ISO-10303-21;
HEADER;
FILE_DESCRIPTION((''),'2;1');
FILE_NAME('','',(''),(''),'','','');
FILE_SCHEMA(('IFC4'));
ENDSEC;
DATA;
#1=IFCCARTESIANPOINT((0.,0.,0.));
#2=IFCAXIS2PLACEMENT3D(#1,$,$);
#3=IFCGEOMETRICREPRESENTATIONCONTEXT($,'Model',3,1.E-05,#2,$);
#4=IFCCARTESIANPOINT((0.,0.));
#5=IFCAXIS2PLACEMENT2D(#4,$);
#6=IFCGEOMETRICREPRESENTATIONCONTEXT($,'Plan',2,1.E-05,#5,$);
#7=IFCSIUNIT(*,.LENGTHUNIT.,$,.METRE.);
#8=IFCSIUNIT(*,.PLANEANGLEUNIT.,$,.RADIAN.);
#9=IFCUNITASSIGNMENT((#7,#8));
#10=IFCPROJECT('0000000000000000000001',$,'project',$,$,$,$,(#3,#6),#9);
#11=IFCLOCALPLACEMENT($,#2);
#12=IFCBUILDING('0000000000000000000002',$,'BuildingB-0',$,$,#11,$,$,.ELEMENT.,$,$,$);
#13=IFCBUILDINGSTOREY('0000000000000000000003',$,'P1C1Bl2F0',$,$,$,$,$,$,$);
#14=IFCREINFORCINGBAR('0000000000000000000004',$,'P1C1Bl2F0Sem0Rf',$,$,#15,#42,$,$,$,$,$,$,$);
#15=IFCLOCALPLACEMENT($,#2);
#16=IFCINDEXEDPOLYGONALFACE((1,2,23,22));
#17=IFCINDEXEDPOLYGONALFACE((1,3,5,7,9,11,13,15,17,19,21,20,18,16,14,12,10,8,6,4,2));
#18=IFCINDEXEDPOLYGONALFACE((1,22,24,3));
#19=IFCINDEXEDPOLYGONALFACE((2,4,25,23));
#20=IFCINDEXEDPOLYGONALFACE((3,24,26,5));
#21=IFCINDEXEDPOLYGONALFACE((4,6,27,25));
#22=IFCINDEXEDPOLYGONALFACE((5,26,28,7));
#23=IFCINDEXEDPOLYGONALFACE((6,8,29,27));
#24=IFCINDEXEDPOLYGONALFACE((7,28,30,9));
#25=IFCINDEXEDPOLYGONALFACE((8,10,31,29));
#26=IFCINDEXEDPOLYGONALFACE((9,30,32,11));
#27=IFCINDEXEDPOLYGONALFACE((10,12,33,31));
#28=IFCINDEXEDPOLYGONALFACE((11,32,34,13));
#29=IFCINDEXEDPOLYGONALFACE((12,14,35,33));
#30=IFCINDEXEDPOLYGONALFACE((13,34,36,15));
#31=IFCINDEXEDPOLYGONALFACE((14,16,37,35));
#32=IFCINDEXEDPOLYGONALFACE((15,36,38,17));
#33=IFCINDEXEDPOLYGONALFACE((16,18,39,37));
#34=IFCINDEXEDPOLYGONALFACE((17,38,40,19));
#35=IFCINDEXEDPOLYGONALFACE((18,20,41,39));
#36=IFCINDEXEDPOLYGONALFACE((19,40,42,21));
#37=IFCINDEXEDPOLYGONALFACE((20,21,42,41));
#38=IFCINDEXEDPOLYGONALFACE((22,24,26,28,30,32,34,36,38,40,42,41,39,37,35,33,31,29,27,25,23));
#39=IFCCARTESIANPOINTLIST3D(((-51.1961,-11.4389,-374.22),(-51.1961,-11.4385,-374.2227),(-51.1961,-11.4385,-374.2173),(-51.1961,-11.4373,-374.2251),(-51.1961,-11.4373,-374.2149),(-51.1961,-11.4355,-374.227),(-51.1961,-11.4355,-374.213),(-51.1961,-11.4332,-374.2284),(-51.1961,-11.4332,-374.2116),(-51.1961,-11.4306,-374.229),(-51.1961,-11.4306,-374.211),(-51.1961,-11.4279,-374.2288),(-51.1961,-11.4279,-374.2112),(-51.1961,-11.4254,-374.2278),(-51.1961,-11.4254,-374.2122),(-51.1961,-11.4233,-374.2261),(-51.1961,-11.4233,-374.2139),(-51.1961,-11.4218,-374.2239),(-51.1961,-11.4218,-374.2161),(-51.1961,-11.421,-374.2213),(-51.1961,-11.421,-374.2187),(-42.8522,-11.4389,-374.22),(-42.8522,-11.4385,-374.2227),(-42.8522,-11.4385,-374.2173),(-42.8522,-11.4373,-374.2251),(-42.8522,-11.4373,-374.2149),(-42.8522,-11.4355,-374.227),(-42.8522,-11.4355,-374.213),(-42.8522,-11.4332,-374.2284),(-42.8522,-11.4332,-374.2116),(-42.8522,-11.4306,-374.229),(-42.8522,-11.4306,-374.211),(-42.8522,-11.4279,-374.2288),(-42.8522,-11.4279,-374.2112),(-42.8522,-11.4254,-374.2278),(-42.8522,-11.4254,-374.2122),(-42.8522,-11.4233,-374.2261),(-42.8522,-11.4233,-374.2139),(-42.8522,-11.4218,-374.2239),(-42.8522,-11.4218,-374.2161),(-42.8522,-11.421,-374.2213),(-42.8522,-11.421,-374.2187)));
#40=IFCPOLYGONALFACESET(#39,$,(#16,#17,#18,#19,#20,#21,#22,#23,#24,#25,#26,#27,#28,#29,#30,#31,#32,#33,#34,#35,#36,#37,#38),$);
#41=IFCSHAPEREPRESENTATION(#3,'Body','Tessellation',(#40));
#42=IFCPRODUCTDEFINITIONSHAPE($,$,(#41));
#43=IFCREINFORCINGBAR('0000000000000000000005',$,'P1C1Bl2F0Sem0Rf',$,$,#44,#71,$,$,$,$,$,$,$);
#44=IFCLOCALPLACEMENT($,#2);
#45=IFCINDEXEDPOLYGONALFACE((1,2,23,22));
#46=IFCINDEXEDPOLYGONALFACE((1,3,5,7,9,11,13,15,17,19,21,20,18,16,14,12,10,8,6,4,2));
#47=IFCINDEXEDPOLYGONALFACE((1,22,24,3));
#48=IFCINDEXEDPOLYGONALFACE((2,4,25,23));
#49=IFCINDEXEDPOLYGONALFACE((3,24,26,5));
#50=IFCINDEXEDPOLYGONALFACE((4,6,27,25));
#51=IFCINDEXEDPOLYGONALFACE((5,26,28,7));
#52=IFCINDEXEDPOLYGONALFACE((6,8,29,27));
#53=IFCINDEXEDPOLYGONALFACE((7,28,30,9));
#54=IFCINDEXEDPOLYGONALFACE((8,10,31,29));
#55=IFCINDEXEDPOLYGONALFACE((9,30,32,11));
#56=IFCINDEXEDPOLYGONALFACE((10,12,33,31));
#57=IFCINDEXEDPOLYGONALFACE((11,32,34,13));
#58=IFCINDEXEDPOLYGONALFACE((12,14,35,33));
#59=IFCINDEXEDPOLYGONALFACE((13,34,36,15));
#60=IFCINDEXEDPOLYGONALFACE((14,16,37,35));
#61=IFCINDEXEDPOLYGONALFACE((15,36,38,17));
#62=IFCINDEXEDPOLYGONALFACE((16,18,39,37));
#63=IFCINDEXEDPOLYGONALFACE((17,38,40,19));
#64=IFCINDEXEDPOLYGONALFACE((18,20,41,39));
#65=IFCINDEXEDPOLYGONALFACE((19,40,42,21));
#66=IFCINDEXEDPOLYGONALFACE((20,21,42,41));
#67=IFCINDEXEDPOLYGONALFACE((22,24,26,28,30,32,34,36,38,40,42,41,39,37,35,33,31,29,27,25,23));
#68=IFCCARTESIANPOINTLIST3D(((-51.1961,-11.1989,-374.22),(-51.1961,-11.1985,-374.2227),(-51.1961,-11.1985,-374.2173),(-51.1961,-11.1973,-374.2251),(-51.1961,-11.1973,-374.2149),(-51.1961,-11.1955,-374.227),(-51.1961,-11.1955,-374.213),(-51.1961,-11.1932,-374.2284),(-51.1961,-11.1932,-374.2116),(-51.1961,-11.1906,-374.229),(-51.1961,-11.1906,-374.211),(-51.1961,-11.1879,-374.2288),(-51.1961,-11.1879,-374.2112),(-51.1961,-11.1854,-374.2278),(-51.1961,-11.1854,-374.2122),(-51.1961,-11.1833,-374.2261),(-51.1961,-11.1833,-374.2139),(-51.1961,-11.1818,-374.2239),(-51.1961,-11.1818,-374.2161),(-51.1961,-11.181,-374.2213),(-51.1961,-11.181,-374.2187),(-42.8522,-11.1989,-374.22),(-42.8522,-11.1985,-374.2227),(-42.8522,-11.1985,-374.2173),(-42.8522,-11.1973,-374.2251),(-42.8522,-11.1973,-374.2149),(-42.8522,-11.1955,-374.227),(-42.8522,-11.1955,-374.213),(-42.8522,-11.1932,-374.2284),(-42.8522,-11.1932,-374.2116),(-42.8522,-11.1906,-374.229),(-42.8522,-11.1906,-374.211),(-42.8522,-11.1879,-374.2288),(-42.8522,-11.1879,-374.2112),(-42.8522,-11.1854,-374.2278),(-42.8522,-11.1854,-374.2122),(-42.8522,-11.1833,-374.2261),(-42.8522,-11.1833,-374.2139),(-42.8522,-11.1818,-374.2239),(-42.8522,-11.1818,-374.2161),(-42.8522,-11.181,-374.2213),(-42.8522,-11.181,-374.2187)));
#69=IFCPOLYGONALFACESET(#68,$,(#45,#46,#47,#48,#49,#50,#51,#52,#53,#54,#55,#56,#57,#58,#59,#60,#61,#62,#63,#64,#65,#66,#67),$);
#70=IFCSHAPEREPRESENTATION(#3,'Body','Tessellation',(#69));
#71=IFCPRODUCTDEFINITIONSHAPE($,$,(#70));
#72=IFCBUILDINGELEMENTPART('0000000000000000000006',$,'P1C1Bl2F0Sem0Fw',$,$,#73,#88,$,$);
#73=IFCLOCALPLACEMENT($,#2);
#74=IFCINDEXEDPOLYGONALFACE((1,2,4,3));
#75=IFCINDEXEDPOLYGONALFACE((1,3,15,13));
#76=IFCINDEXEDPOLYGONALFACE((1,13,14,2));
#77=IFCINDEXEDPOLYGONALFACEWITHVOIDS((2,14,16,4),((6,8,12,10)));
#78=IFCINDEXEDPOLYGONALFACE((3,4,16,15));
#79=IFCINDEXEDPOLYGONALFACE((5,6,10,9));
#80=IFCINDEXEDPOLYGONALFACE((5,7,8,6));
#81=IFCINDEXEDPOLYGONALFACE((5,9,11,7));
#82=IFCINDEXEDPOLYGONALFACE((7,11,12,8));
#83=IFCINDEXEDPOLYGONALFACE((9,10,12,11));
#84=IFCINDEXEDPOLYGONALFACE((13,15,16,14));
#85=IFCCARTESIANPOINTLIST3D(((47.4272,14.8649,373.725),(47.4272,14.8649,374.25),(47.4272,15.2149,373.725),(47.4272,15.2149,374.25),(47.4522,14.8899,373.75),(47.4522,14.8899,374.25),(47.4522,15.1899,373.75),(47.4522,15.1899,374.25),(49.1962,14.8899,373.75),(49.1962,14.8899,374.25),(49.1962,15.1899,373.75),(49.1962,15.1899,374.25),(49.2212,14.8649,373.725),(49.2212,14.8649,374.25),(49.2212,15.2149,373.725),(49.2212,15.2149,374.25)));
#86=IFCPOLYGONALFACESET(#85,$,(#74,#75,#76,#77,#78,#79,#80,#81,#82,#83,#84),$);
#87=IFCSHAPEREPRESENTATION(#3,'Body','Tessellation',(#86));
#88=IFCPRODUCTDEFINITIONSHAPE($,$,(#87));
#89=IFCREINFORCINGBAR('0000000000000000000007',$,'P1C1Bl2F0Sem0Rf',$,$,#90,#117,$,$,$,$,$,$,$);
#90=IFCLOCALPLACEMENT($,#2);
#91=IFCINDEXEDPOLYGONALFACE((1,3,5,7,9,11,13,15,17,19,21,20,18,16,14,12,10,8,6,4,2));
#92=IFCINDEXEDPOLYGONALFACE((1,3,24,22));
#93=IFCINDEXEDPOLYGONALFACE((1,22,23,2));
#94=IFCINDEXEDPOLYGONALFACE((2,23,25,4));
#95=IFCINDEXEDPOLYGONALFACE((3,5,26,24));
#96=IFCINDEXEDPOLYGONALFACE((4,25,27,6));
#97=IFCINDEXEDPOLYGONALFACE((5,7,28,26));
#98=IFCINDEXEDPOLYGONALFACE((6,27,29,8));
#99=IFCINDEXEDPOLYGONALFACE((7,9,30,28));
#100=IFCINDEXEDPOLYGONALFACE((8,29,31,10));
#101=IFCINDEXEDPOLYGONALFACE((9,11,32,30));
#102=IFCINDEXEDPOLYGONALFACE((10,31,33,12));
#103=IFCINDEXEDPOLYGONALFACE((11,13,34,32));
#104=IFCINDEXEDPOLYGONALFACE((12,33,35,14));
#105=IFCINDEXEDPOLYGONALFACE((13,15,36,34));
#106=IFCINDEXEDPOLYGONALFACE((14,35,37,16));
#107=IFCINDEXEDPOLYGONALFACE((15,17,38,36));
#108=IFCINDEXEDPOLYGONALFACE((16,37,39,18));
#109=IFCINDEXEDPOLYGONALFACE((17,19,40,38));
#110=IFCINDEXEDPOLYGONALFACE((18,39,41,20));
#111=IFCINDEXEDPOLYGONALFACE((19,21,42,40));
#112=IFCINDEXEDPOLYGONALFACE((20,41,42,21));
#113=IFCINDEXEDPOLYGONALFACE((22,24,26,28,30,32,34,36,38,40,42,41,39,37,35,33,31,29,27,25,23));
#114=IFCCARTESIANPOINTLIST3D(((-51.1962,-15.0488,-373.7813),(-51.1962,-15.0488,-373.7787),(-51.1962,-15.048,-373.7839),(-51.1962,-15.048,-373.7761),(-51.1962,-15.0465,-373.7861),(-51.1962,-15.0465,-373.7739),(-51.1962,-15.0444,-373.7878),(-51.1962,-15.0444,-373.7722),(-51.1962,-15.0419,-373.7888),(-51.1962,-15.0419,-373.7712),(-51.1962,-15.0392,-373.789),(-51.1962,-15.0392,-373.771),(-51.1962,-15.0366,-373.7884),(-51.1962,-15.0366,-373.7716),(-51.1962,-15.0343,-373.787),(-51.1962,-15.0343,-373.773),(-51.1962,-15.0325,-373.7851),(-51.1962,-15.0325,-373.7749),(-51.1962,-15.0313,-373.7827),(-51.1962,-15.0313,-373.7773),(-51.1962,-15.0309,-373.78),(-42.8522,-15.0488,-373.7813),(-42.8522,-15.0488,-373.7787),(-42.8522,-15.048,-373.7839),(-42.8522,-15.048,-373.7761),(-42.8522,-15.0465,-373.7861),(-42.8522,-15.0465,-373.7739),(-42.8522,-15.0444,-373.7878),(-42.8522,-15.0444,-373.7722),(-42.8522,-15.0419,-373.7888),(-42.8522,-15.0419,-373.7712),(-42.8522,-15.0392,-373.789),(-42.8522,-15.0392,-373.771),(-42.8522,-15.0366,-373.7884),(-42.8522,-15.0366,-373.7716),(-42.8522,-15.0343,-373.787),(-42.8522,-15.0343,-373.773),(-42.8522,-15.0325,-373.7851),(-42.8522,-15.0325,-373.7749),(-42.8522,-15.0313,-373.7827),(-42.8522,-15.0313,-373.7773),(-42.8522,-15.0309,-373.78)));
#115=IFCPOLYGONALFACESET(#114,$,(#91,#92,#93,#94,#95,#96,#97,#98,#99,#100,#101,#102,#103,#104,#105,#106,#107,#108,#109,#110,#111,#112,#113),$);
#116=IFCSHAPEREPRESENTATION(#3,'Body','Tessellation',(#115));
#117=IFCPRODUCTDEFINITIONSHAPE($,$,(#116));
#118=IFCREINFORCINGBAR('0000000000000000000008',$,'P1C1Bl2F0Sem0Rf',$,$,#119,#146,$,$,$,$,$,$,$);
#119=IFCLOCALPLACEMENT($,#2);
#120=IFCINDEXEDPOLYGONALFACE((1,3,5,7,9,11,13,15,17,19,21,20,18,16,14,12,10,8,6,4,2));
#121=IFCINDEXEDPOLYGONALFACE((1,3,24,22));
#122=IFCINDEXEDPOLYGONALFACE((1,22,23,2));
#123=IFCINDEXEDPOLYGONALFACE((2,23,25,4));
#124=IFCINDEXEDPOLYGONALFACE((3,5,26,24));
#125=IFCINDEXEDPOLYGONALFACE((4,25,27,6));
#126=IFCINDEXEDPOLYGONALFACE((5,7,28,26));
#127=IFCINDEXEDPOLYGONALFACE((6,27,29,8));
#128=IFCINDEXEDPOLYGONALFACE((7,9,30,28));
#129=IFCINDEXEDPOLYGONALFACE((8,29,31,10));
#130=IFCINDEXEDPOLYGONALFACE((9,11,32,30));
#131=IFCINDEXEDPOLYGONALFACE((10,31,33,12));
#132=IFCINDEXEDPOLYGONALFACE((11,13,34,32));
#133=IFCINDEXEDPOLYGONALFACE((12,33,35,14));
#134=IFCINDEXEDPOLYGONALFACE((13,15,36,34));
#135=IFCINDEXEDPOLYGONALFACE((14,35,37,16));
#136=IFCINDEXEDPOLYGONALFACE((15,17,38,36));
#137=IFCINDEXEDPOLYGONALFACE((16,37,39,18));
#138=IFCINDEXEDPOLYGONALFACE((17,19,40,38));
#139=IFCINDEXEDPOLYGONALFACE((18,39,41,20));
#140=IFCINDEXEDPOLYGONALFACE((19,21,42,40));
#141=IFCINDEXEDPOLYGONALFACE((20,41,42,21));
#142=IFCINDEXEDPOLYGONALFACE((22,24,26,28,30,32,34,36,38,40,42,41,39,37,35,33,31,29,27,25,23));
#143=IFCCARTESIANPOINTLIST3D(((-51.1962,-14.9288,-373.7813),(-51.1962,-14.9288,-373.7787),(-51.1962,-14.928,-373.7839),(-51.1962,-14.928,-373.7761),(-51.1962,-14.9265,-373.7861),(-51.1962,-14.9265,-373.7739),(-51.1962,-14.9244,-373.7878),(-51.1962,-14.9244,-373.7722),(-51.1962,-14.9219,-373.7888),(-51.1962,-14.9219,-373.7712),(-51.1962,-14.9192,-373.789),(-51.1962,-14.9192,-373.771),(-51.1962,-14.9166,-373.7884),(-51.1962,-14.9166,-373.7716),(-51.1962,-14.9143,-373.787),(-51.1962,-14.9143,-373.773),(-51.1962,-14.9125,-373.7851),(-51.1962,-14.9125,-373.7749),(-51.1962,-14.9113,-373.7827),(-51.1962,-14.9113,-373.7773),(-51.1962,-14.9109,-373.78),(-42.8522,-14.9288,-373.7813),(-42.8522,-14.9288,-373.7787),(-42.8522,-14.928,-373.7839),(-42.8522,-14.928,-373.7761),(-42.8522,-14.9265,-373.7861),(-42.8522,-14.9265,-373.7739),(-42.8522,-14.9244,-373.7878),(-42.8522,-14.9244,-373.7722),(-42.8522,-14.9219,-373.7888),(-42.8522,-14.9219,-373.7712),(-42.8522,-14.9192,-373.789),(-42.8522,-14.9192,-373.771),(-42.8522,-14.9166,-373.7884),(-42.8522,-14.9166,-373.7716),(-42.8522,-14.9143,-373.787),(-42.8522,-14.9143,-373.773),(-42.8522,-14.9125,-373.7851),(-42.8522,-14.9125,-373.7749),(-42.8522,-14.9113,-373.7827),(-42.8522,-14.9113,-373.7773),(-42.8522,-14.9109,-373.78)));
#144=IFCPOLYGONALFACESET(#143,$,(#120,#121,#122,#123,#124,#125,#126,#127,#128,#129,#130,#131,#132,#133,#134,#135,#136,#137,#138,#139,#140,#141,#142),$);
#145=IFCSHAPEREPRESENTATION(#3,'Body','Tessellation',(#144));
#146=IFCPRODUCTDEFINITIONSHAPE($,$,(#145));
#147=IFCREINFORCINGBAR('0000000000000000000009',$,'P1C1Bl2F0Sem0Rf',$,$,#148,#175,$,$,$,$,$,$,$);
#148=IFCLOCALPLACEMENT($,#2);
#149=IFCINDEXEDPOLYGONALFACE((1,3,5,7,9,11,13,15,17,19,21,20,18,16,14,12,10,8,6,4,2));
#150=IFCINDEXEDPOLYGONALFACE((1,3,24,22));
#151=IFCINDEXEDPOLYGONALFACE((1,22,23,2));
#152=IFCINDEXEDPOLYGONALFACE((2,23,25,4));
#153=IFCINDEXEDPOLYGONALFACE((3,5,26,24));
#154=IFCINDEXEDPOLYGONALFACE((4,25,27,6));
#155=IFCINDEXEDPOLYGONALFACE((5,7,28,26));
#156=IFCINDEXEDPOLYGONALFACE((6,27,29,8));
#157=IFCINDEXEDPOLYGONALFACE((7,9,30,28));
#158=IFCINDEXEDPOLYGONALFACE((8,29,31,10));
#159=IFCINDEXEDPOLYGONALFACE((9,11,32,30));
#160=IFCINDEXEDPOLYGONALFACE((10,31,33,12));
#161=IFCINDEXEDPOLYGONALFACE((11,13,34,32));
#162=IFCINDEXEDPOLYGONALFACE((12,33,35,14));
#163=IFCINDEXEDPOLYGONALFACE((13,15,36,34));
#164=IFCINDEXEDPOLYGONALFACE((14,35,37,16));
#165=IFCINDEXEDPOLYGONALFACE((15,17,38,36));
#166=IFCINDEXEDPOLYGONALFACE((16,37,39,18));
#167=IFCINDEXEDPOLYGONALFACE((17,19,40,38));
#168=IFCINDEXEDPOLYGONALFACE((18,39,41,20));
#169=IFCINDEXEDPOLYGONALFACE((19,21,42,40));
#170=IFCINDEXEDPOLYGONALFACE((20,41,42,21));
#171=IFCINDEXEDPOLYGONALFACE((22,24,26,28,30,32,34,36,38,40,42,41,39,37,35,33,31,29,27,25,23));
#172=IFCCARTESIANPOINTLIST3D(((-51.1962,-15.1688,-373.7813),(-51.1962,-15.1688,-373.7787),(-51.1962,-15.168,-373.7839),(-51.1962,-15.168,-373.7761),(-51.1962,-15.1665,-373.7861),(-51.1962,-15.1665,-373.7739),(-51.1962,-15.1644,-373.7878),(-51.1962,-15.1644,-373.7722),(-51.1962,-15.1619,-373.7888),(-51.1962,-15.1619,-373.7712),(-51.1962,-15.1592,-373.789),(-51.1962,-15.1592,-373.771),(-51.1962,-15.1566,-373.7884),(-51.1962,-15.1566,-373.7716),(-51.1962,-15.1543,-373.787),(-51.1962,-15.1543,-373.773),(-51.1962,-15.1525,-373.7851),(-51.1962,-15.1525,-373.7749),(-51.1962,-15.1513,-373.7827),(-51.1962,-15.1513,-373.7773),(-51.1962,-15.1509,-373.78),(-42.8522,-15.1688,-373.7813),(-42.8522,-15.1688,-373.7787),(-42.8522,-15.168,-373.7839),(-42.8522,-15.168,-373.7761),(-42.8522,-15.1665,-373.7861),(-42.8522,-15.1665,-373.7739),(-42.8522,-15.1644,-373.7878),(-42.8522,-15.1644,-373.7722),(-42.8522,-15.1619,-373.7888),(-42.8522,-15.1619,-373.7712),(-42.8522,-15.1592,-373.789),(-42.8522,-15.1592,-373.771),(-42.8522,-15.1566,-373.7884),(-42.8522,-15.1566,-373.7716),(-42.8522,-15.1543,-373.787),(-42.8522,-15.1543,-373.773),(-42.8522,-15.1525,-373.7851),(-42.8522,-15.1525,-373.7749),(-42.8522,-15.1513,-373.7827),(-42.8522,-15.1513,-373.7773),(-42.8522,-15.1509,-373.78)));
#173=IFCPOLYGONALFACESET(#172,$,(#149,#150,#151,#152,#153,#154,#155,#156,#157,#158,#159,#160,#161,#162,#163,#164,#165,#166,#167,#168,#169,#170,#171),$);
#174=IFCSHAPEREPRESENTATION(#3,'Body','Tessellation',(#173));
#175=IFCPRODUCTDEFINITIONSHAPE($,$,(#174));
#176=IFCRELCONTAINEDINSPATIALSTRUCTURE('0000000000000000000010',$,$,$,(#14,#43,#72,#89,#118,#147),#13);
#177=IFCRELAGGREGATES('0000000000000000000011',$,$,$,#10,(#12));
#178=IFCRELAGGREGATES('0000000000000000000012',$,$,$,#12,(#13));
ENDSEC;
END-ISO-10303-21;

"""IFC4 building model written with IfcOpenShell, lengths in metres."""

from ifc_helpers import new_model, entity, si_unit, origin, origin_2d, place, context, project, spatial, polyline, outline, extrude, element, save


model = new_model("IFC4")

# Units and contexts
model_context = context("Model", 3, precision=1e-05, world=origin())
plan_context = context("Plan", 2, precision=1e-05, world=origin_2d())
ifc_project = project(units=[si_unit("LENGTHUNIT", "METRE"), si_unit("PLANEANGLEUNIT", "RADIAN")], contexts=[model_context, plan_context])

# Building, storey
building_placement = place(None, origin())
building = spatial("IfcBuilding", under=ifc_project, at=building_placement, Name="BuildingB-0", CompositionType="ELEMENT")
storey = spatial("IfcBuildingStorey", under=building, Name="P1C1Bl2F0")

# Reinforcing bars
element("IfcReinforcingBar", 1, inside=storey, Name="P1C1Bl2F0Sem0Rf", context=model_context, shape_type="SweptSolid", body=[
    entity("IfcSurfaceCurveSweptAreaSolid", entity("IfcCircleProfileDef", "AREA", None, None, 0.009), None, entity("IfcPolyline", [entity("IfcCartesianPoint", [51.1961, 11.4299, 374.22]), entity("IfcCartesianPoint", [42.8522, 11.4299, 374.22])]), None, None, entity("IfcPlane", entity("IfcAxis2Placement3D", entity("IfcCartesianPoint", [51.1961, 11.4299, 374.22]), entity("IfcDirection", [0.0, 0.0, 1.0]), entity("IfcDirection", [1.0, 0.0, 0.0])))),
])
element("IfcReinforcingBar", 2, inside=storey, Name="P1C1Bl2F0Sem0Rf", context=model_context, shape_type="SweptSolid", body=[
    entity("IfcSurfaceCurveSweptAreaSolid", entity("IfcCircleProfileDef", "AREA", None, None, 0.009), None, entity("IfcPolyline", [entity("IfcCartesianPoint", [51.1961, 11.1899, 374.22]), entity("IfcCartesianPoint", [42.8522, 11.1899, 374.22])]), None, None, entity("IfcPlane", entity("IfcAxis2Placement3D", entity("IfcCartesianPoint", [51.1961, 11.1899, 374.22]), entity("IfcDirection", [0.0, 0.0, 1.0]), entity("IfcDirection", [1.0, 0.0, 0.0])))),
])

# Building element part, opening
building_element_part_1 = element("IfcBuildingElementPart", 3, inside=storey, Name="P1C1Bl2F0Sem0Fw", context=model_context, shape_type="SweptSolid", body=[
    extrude(outline(polyline([(47.4272, 14.8649, 373.725), (47.4272, 15.2149, 373.725), (49.2212, 15.2149, 373.725), (49.2212, 14.8649, 373.725), (47.4272, 14.8649, 373.725)])), None, (0.0, 0.0, 1.0), 0.525),
])
element("IfcOpeningElement", 4, inside=storey, cuts=building_element_part_1, context=model_context, shape_type="SweptSolid", body=[
    extrude(outline(polyline([(47.4522, 14.8899, 373.75), (47.4522, 15.1899, 373.75), (49.1962, 15.1899, 373.75), (49.1962, 14.8899, 373.75), (47.4522, 14.8899, 373.75)])), None, (0.0, 0.0, 1.0), 0.5),
])

# Reinforcing bars
element("IfcReinforcingBar", 5, inside=storey, Name="P1C1Bl2F0Sem0Rf", context=model_context, shape_type="SweptSolid", body=[
    entity("IfcSurfaceCurveSweptAreaSolid", entity("IfcCircleProfileDef", "AREA", None, None, 0.009), None, entity("IfcPolyline", [entity("IfcCartesianPoint", [42.8522, 15.0399, 373.78]), entity("IfcCartesianPoint", [51.1962, 15.0399, 373.78])]), None, None, entity("IfcPlane", entity("IfcAxis2Placement3D", entity("IfcCartesianPoint", [42.8522, 15.0399, 373.78]), entity("IfcDirection", [0.0, 0.0, 1.0]), entity("IfcDirection", [1.0, 0.0, 0.0])))),
])
element("IfcReinforcingBar", 6, inside=storey, Name="P1C1Bl2F0Sem0Rf", context=model_context, shape_type="SweptSolid", body=[
    entity("IfcSurfaceCurveSweptAreaSolid", entity("IfcCircleProfileDef", "AREA", None, None, 0.009), None, entity("IfcPolyline", [entity("IfcCartesianPoint", [42.8522, 14.9199, 373.78]), entity("IfcCartesianPoint", [51.1962, 14.9199, 373.78])]), None, None, entity("IfcPlane", entity("IfcAxis2Placement3D", entity("IfcCartesianPoint", [42.8522, 14.9199, 373.78]), entity("IfcDirection", [0.0, 0.0, 1.0]), entity("IfcDirection", [1.0, 0.0, 0.0])))),
])
element("IfcReinforcingBar", 7, inside=storey, Name="P1C1Bl2F0Sem0Rf", context=model_context, shape_type="SweptSolid", body=[
    entity("IfcSurfaceCurveSweptAreaSolid", entity("IfcCircleProfileDef", "AREA", None, None, 0.009), None, entity("IfcPolyline", [entity("IfcCartesianPoint", [42.8522, 15.1599, 373.78]), entity("IfcCartesianPoint", [51.1962, 15.1599, 373.78])]), None, None, entity("IfcPlane", entity("IfcAxis2Placement3D", entity("IfcCartesianPoint", [42.8522, 15.1599, 373.78]), entity("IfcDirection", [0.0, 0.0, 1.0]), entity("IfcDirection", [1.0, 0.0, 0.0])))),
])

save(model, "model.ifc")
